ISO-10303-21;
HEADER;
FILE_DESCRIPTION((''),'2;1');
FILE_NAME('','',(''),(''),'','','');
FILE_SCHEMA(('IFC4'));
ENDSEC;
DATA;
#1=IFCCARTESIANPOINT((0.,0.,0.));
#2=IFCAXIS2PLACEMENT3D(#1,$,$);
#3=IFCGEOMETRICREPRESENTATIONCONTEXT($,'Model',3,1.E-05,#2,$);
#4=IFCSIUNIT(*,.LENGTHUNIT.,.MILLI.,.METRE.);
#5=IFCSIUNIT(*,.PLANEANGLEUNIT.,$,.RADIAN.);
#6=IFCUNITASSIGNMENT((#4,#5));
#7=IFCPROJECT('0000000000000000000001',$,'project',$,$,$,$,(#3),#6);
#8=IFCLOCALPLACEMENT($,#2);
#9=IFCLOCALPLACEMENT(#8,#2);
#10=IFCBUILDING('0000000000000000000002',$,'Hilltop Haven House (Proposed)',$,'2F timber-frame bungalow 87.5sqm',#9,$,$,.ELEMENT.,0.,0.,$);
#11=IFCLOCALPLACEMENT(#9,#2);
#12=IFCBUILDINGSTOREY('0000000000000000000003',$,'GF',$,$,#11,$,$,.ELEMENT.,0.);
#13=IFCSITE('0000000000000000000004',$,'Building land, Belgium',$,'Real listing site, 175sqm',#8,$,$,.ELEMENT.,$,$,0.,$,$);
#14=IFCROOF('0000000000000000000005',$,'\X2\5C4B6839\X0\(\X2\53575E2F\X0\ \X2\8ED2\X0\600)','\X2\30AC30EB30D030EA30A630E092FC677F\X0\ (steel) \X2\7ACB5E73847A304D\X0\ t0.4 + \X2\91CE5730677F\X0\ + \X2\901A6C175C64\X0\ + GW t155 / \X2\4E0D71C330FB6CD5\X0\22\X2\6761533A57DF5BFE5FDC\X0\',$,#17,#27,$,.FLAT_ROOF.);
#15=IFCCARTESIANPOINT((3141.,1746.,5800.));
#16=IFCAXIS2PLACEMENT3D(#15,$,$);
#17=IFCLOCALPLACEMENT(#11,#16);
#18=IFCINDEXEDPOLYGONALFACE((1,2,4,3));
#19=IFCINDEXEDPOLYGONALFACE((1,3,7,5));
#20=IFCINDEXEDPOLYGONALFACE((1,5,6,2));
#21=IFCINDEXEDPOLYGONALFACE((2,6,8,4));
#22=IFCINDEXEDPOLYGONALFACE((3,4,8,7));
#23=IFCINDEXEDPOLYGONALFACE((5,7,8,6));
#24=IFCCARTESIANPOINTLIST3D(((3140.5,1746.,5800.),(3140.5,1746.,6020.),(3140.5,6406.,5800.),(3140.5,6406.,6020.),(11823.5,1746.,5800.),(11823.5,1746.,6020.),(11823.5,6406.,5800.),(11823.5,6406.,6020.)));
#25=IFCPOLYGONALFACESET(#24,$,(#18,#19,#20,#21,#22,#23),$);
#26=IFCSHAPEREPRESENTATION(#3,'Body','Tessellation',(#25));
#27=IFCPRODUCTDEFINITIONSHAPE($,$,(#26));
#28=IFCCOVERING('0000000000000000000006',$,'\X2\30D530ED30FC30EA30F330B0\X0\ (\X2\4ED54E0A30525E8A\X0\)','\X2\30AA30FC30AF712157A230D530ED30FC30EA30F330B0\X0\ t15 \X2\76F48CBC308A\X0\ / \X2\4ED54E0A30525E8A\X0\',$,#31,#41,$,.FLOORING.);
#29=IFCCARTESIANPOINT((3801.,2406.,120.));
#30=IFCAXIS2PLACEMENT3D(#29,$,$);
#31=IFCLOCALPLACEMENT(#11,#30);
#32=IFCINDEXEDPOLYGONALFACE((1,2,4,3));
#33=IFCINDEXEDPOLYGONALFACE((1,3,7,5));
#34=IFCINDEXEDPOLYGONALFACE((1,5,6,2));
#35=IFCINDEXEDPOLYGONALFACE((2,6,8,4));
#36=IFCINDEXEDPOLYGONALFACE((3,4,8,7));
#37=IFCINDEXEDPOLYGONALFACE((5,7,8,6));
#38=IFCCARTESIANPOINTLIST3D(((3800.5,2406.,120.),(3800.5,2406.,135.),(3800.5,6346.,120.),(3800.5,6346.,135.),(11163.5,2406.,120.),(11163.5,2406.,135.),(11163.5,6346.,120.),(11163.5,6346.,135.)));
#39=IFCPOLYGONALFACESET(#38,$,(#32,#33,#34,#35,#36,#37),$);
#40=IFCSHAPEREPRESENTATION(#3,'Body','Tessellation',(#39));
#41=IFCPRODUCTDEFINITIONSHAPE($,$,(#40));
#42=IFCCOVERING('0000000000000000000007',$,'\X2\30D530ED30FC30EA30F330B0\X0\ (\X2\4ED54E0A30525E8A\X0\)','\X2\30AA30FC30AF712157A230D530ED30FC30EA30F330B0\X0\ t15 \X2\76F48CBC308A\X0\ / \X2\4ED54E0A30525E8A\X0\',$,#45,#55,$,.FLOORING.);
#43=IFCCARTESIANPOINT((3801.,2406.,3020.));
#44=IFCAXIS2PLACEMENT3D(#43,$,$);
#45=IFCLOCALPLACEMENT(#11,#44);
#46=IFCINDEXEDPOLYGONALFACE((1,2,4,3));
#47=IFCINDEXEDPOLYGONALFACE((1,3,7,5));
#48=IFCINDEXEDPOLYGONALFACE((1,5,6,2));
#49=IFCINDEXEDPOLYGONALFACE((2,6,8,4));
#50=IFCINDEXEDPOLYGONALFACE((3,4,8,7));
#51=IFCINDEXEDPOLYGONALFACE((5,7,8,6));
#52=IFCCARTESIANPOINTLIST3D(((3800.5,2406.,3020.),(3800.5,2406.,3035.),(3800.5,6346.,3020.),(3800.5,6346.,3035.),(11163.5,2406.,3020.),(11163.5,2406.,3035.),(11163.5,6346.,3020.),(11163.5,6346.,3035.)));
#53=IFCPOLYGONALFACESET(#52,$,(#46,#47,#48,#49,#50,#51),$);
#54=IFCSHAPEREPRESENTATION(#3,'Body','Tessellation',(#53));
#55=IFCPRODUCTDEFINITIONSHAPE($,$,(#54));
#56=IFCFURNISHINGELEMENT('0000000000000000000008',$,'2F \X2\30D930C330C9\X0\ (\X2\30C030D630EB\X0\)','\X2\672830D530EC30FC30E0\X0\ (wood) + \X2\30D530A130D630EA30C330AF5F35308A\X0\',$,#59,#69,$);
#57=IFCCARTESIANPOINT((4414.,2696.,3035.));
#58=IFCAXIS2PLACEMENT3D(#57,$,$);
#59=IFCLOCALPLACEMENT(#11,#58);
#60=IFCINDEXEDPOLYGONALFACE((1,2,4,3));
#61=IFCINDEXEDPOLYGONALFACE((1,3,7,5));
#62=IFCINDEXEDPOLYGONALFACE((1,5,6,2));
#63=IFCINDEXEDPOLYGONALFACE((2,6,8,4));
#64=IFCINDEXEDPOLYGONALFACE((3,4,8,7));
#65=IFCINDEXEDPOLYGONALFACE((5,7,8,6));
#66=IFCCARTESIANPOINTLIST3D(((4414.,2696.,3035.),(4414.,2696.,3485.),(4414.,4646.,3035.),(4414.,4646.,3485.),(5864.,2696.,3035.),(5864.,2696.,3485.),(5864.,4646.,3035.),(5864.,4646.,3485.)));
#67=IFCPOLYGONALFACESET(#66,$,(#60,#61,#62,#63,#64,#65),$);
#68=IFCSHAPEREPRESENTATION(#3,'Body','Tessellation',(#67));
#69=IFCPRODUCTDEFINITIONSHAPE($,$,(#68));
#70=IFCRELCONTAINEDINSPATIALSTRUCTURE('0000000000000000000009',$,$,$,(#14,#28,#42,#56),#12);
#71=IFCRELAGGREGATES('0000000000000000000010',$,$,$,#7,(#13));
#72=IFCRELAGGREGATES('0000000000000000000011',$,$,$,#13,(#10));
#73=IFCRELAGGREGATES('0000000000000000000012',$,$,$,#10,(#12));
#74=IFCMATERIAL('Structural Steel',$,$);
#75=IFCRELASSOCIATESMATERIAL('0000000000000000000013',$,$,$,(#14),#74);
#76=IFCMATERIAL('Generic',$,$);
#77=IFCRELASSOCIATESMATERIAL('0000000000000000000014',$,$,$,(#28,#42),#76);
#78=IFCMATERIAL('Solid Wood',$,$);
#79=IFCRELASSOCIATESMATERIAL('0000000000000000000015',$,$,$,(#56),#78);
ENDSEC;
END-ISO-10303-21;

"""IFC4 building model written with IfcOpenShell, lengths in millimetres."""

from ifc_helpers import new_model, si_unit, frame, frame_2d, origin, place, context, project, spatial, rectangle, extrude, material, element, save


model = new_model("IFC4")

# Units and contexts
model_context = context("Model", 3, precision=1e-05, world=origin())
ifc_project = project(units=[si_unit("LENGTHUNIT", "METRE", prefix="MILLI"), si_unit("PLANEANGLEUNIT", "RADIAN")], contexts=[model_context])

# Site, building, storey
site_placement = place(None, origin())
site = spatial("IfcSite", under=ifc_project, at=site_placement, Name="Building land, Belgium", ObjectType="Real listing site, 175sqm", CompositionType="ELEMENT", RefElevation=0.0)
building_placement = place(site_placement, origin())
building = spatial("IfcBuilding", under=site, at=building_placement, Name="Hilltop Haven House (Proposed)", ObjectType="2F timber-frame bungalow 87.5sqm", CompositionType="ELEMENT", ElevationOfRefHeight=0.0, ElevationOfTerrain=0.0)
storey_placement = place(building_placement, origin())
storey = spatial("IfcBuildingStorey", under=building, at=storey_placement, Name="GF", CompositionType="ELEMENT", Elevation=0.0)

# Shared definitions
ifc_material_1 = material(Name="Solid Wood")

# Roof
ifc_material_2 = material(Name="Structural Steel")
for number, where, name in (
    (1, (3141.0, 1746.0, 5800.0), "屋根(南帯 軒600)"),
):
    element("IfcRoof", number, at=place(storey_placement, frame(where)), inside=storey, material=ifc_material_2, Name=name, Description="ガルバリウム鋼板 (steel) 立平葺き t0.4 + 野地板 + 通気層 + GW t155 / 不燃・法22条区域対応", PredefinedType="FLAT_ROOF", context=model_context, shape_type="SweptSolid", body=[
        extrude(rectangle(XDim=8683.0, YDim=4660.0, at=frame_2d((4341.0, 2330.0))), frame((3141.0, 1746.0, 5800.0)), (0.0, 0.0, 1.0), 220.0),
    ])

# Coverings
ifc_material_3 = material(Name="Generic")
covering_1_placement = place(storey_placement, frame((3801.0, 2406.0, 120.0)))
element("IfcCovering", 2, at=covering_1_placement, inside=storey, material=ifc_material_3, Name="フローリング (仕上げ床)", Description="オーク無垢フローリング t15 直貼り / 仕上げ床", PredefinedType="FLOORING", context=model_context, shape_type="SweptSolid", body=[
    extrude(rectangle(XDim=7363.0, YDim=3940.0, at=frame_2d((3681.0, 1970.0))), frame((3801.0, 2406.0, 120.0)), (0.0, 0.0, 1.0), 15.0),
])
covering_2_placement = place(storey_placement, frame((3801.0, 2406.0, 3020.0)))
element("IfcCovering", 3, at=covering_2_placement, inside=storey, material=ifc_material_3, Name="フローリング (仕上げ床)", Description="オーク無垢フローリング t15 直貼り / 仕上げ床", PredefinedType="FLOORING", context=model_context, shape_type="SweptSolid", body=[
    extrude(rectangle(XDim=7363.0, YDim=3940.0, at=frame_2d((3681.0, 1970.0))), frame((3801.0, 2406.0, 3020.0)), (0.0, 0.0, 1.0), 15.0),
])

# Furnishing element
furnishing_placement = place(storey_placement, frame((4414.0, 2696.0, 3035.0)))
element("IfcFurnishingElement", 4, at=furnishing_placement, inside=storey, material=ifc_material_1, Name="2F ベッド (ダブル)", Description="木フレーム (wood) + ファブリック張り", context=model_context, shape_type="SweptSolid", body=[
    extrude(rectangle(XDim=1450.0, YDim=1950.0, at=frame_2d((725.0, 975.0))), frame((4414.0, 2696.0, 3035.0)), (0.0, 0.0, 1.0), 450.0),
])

save(model, "model.ifc")
